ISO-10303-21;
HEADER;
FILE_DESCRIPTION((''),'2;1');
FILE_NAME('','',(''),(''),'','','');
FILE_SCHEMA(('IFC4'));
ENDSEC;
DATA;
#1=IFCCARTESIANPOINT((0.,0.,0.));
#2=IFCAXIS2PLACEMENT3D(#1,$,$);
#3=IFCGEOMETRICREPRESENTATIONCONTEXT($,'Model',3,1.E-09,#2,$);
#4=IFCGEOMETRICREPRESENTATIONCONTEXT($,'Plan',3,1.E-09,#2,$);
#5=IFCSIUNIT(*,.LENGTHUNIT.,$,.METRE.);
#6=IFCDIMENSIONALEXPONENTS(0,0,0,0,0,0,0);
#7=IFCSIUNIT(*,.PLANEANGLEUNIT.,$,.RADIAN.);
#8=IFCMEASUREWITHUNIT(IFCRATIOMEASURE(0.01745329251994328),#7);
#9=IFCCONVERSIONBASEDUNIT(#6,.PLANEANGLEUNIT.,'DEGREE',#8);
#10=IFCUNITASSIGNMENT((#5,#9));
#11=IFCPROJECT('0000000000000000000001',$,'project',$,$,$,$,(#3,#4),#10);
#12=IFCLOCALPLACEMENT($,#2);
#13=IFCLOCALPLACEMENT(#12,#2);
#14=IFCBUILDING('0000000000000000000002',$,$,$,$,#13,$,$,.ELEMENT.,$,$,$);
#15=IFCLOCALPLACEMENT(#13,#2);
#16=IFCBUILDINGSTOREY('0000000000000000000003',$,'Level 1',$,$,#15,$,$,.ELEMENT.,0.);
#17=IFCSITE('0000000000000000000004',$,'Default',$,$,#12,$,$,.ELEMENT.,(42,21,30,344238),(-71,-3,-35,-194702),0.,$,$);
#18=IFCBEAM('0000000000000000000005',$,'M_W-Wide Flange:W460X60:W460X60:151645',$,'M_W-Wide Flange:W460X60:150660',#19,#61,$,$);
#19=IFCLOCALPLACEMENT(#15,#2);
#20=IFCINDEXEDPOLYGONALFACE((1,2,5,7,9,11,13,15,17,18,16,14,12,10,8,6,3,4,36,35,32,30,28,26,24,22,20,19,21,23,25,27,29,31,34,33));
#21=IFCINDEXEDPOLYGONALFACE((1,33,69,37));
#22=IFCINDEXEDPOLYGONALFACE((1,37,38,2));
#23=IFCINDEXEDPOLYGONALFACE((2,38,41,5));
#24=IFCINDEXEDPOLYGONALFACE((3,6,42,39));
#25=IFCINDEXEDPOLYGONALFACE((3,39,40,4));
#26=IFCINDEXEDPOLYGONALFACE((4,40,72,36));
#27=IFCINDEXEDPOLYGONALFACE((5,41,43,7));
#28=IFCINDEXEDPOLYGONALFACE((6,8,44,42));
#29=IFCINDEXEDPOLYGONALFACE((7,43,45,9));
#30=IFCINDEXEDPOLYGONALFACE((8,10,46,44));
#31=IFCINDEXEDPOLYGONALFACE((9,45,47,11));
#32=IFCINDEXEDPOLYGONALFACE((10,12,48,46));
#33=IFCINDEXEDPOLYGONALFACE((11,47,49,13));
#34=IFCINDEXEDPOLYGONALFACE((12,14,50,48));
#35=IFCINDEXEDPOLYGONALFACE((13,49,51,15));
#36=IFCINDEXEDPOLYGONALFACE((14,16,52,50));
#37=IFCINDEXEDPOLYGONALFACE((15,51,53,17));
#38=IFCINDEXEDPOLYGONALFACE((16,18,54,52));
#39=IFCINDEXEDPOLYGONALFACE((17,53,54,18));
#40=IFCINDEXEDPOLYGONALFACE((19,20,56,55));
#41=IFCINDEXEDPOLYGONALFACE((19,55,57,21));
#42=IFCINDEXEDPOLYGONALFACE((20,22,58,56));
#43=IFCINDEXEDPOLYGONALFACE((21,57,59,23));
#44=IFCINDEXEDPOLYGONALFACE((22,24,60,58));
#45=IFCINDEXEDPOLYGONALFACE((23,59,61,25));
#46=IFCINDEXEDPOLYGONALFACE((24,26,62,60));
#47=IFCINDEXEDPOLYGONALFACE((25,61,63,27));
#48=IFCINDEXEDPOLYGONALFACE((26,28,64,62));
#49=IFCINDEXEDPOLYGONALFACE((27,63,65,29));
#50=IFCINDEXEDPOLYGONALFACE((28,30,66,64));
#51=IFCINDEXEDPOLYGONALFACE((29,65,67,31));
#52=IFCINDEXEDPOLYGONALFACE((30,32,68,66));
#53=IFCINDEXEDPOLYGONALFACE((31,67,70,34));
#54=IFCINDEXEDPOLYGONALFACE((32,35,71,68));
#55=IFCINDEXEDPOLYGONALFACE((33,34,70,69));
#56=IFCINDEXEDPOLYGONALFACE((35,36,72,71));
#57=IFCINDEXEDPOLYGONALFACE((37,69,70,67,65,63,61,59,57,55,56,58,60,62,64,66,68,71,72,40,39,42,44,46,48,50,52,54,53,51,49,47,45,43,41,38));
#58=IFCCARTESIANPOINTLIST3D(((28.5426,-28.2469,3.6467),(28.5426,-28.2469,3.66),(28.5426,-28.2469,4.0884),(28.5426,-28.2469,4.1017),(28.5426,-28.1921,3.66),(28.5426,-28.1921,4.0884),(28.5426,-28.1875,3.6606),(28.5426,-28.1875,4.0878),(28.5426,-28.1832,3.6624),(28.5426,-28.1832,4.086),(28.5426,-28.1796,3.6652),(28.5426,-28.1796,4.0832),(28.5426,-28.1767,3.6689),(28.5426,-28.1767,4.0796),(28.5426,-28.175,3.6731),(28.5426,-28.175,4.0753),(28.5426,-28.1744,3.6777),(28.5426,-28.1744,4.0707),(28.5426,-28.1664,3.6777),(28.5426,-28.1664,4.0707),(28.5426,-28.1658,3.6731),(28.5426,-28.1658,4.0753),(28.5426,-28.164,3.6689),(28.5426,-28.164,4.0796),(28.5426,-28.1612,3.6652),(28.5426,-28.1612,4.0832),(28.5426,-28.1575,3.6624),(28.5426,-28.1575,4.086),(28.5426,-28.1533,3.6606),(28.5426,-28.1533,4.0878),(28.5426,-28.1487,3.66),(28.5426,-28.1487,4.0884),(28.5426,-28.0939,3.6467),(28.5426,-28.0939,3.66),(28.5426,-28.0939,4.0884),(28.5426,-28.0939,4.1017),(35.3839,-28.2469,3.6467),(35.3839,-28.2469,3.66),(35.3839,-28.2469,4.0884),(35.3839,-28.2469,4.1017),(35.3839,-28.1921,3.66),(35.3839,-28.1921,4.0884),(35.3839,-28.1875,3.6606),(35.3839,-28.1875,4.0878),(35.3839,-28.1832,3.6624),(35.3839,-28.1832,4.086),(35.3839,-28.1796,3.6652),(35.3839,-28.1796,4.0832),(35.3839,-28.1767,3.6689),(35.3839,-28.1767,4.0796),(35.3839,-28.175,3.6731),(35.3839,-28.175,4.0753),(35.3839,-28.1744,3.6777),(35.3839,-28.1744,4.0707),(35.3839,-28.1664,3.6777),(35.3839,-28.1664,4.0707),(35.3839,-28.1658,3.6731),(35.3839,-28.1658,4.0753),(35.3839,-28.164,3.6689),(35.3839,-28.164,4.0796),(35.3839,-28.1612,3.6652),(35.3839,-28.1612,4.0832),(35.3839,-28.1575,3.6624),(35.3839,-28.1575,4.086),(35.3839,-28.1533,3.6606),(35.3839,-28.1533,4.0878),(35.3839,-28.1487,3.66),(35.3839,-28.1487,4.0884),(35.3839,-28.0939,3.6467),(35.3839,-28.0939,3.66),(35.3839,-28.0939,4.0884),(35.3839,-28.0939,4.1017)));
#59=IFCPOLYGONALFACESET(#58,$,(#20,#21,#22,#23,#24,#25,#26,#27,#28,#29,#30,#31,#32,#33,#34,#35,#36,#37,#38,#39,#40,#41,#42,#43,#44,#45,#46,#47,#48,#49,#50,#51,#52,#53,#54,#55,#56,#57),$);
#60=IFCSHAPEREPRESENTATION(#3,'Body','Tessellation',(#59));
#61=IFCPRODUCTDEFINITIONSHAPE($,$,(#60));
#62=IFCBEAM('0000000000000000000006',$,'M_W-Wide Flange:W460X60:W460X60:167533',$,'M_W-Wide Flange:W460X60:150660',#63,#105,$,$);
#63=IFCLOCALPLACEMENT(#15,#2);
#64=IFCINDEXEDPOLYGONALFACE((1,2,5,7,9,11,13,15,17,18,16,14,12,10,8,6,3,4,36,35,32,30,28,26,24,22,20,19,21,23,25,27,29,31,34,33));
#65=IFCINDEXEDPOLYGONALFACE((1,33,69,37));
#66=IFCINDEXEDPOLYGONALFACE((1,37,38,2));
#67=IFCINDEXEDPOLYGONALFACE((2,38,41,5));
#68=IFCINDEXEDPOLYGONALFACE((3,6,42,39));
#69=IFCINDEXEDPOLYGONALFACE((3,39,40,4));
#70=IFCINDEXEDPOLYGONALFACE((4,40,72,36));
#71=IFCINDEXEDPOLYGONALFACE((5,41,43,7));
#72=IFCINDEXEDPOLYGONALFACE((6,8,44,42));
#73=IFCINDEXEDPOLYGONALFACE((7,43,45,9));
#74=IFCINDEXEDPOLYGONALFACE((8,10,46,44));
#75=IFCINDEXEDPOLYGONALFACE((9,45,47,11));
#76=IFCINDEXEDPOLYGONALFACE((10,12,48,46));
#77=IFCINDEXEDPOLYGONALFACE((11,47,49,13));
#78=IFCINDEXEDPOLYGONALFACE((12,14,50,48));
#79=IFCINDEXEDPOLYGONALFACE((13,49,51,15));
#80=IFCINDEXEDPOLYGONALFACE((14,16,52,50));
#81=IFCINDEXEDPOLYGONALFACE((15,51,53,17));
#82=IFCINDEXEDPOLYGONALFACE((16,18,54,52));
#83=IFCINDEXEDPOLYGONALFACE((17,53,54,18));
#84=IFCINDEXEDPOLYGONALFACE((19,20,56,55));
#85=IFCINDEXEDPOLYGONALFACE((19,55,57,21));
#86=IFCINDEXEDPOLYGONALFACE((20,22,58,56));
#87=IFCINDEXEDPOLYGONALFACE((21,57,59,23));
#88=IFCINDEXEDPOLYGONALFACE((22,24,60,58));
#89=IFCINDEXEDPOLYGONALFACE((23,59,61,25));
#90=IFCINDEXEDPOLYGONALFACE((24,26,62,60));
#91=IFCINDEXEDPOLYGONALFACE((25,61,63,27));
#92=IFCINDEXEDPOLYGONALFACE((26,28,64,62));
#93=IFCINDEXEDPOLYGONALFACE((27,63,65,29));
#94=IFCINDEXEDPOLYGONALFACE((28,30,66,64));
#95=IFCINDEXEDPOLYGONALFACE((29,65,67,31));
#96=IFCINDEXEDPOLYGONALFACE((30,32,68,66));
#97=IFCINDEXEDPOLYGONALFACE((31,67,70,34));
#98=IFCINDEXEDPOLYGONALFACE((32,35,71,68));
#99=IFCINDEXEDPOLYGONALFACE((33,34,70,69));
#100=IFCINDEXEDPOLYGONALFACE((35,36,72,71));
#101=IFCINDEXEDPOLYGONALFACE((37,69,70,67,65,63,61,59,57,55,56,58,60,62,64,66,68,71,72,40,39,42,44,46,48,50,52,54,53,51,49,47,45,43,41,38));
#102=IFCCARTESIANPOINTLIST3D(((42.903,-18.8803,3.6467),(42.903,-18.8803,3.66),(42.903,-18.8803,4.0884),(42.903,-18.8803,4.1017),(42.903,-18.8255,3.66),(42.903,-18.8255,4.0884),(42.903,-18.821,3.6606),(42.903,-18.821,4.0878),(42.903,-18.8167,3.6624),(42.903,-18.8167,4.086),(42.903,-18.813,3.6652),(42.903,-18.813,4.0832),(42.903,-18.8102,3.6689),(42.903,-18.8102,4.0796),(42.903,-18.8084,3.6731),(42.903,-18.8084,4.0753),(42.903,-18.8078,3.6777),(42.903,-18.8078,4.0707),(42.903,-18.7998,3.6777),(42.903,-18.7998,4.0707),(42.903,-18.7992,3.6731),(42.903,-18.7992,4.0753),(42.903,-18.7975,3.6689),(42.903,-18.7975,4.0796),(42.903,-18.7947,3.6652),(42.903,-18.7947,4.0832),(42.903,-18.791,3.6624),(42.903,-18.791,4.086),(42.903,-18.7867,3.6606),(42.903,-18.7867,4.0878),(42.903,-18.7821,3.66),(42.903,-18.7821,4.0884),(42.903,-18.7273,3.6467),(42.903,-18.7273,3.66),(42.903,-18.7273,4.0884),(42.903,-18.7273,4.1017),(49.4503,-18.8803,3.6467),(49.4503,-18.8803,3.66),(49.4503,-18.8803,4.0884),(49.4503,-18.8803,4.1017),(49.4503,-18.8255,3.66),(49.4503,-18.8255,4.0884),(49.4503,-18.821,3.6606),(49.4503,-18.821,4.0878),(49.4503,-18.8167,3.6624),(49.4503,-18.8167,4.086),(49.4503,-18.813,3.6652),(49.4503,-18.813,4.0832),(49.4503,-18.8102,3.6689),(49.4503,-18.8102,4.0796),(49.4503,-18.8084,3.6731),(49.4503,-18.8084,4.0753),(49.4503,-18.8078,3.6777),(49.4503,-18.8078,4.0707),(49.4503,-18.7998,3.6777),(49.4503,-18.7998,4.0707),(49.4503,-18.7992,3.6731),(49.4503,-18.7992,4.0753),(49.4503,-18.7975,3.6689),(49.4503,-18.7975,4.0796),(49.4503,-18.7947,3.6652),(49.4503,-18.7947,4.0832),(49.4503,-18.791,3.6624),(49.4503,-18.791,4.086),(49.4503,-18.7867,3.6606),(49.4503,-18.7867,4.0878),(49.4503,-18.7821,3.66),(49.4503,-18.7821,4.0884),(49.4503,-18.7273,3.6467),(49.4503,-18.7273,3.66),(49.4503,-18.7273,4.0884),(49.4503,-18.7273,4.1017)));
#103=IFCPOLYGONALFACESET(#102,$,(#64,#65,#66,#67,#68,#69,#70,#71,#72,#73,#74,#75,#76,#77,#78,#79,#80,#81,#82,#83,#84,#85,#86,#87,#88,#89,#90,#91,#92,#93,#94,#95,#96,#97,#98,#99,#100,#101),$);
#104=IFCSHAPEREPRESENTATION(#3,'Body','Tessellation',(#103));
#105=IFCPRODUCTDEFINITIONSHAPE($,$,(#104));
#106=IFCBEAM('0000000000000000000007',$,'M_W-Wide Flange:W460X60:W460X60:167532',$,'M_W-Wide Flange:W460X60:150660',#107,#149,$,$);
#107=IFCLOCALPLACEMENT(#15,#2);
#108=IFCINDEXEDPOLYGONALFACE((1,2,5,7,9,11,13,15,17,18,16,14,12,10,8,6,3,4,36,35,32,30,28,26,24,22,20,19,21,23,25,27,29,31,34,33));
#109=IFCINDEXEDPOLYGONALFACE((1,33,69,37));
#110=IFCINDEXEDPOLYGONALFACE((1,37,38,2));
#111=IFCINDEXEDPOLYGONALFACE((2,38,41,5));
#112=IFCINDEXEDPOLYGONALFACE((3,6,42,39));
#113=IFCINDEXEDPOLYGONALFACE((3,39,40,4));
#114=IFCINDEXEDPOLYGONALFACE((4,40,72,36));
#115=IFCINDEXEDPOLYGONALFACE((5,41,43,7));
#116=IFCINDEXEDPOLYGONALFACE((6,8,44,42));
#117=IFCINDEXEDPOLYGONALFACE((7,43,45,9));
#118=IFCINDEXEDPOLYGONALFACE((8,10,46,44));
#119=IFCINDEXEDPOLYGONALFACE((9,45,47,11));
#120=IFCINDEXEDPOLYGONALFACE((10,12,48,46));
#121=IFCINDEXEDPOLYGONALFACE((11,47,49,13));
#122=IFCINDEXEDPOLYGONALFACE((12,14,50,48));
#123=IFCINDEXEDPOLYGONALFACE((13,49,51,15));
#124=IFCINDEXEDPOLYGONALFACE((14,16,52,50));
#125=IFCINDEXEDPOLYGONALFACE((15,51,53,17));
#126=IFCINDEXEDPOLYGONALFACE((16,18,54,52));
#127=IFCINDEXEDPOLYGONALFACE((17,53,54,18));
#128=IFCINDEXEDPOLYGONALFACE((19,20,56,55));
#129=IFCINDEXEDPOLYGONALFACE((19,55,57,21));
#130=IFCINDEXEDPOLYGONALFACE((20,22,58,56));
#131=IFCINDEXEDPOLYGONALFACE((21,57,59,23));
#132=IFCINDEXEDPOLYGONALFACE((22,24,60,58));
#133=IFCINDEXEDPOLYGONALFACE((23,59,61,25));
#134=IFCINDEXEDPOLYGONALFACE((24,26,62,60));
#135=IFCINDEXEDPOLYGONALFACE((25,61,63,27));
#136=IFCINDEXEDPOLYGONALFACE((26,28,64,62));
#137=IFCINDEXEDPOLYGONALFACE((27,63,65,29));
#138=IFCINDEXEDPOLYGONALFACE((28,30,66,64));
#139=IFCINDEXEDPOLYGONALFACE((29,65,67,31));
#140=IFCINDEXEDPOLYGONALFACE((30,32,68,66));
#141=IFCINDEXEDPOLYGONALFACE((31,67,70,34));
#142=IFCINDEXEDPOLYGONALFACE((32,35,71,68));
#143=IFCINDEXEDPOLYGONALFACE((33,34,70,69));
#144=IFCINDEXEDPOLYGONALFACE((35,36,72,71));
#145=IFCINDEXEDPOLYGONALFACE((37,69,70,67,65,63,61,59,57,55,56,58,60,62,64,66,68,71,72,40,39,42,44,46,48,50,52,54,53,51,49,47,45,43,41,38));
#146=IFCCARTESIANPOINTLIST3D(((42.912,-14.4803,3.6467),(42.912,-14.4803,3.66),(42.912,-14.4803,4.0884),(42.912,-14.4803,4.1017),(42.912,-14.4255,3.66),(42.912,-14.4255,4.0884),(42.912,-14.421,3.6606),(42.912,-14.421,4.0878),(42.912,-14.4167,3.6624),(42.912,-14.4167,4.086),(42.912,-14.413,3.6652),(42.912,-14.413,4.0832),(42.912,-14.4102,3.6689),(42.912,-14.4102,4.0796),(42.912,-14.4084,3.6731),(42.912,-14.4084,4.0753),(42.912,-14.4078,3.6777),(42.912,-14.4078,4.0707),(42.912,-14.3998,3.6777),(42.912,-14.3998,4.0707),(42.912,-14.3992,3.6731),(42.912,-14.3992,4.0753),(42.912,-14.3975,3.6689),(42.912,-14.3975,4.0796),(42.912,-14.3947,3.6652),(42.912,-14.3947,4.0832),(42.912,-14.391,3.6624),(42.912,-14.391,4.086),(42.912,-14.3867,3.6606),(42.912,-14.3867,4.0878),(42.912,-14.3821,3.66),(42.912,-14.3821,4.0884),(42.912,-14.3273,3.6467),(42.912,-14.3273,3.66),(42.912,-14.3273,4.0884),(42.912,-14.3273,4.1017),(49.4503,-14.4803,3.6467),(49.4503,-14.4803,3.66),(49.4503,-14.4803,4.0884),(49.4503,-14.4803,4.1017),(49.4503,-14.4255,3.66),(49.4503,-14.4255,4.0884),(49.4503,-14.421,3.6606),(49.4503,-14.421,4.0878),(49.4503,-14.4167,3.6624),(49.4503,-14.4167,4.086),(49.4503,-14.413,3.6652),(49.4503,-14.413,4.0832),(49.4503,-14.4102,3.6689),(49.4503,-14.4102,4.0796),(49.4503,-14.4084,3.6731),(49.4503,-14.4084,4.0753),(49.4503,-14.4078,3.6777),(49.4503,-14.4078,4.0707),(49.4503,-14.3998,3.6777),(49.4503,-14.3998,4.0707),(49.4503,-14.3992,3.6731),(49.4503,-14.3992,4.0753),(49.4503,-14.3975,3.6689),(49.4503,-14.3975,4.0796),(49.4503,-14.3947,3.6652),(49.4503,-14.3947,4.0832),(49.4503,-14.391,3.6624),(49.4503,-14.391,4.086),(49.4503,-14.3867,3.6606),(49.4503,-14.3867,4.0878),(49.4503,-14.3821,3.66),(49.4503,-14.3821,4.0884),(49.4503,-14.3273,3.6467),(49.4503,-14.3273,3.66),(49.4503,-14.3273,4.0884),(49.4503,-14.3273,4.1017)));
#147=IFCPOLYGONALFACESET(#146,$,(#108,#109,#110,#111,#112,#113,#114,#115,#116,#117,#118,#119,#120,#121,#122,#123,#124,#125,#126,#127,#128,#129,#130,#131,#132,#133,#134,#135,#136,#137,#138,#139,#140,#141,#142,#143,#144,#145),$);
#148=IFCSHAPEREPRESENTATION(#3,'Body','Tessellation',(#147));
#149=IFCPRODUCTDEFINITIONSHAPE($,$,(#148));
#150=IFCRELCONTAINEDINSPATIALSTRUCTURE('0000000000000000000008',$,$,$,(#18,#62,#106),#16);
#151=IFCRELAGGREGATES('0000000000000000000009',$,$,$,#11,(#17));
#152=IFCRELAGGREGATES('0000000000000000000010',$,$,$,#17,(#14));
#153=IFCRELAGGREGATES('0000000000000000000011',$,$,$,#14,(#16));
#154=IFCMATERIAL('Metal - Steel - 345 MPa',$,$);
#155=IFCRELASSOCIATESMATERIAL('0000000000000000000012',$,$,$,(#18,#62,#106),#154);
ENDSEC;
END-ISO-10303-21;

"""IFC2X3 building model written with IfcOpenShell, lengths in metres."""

from ifc_helpers import new_model, entity, si_unit, converted_unit, frame, frame_2d, origin, place, context, project, spatial, polyline, circle_curve, parameter, trimmed, segment, composite_curve, outline, extrude, material, element, save


model = new_model("IFC2X3")

# Units and contexts
model_context = context("Model", 3, precision=1e-09, world=origin())
plan_context = context("Plan", 3, precision=1e-09, world=origin())
ifc_project = project(units=[si_unit("LENGTHUNIT", "METRE"), converted_unit("PLANEANGLEUNIT", "DEGREE", entity("IfcRatioMeasure", 0.01745329251994328), si_unit("PLANEANGLEUNIT", "RADIAN"), dimensions=[0, 0, 0, 0, 0, 0, 0])], contexts=[model_context, plan_context])

# Site, building, storey
site_placement = place(None, origin())
site = spatial("IfcSite", under=ifc_project, at=site_placement, Name="Default", CompositionType="ELEMENT", RefLatitude=(42, 21, 30, 344238), RefLongitude=(-71, -3, -35, -194702), RefElevation=0.0)
building_placement = place(site_placement, origin())
building = spatial("IfcBuilding", under=site, at=building_placement, CompositionType="ELEMENT")
storey_placement = place(building_placement, origin())
storey = spatial("IfcBuildingStorey", under=building, at=storey_placement, Name="Level 1", CompositionType="ELEMENT", Elevation=0.0)

# Beams
ifc_material = material(Name="Metal - Steel - 345 MPa")
beam_1_placement = place(storey_placement, frame((28.4279, -28.1704, 4.2672), z_axis=(0.0, 0.0, 1.0), x_axis=(0.0, -1.0, 0.0)))
element("IfcBeam", 1, at=beam_1_placement, inside=storey, material=ifc_material, Name="M_W-Wide Flange:W460X60:W460X60:151645", ObjectType="M_W-Wide Flange:W460X60:150660", context=model_context, shape_type="SweptSolid", body=[
    extrude(outline(composite_curve([segment(polyline([(-0.0765, -0.2142), (-0.0765, -0.2275)]), True, "CONTINUOUS"), segment(polyline([(-0.0765, -0.2275), (0.0765, -0.2275)]), True, "CONTINUOUS"), segment(polyline([(0.0765, -0.2275), (0.0765, -0.2142)]), True, "CONTINUOUS"), segment(polyline([(0.0765, -0.2142), (0.0217, -0.2142)]), True, "CONTINUOUS"), segment(trimmed(circle_curve(frame_2d((0.0217, -0.1965), x_axis=(0.0, -1.0)), 0.0177), [parameter(270.0)], [parameter(360.0)], True, "PARAMETER"), False, "CONTINUOUS"), segment(polyline([(0.004, -0.1965), (0.004, 0.1965)]), True, "CONTINUOUS"), segment(trimmed(circle_curve(frame_2d((0.0217, 0.1965), x_axis=(-1.0, 0.0)), 0.0177), [parameter(270.0)], [parameter(360.0)], True, "PARAMETER"), False, "CONTINUOUS"), segment(polyline([(0.0217, 0.2142), (0.0765, 0.2142)]), True, "CONTINUOUS"), segment(polyline([(0.0765, 0.2142), (0.0765, 0.2275)]), True, "CONTINUOUS"), segment(polyline([(0.0765, 0.2275), (-0.0765, 0.2275)]), True, "CONTINUOUS"), segment(polyline([(-0.0765, 0.2275), (-0.0765, 0.2142)]), True, "CONTINUOUS"), segment(polyline([(-0.0765, 0.2142), (-0.0217, 0.2142)]), True, "CONTINUOUS"), segment(trimmed(circle_curve(frame_2d((-0.0217, 0.1965), x_axis=(0.0, 1.0)), 0.0177), [parameter(270.0)], [parameter(360.0)], True, "PARAMETER"), False, "CONTINUOUS"), segment(polyline([(-0.004, 0.1965), (-0.004, -0.1965)]), True, "CONTINUOUS"), segment(trimmed(circle_curve(frame_2d((-0.0217, -0.1965), x_axis=(1.0, 0.0)), 0.0177), [parameter(270.0)], [parameter(0.0)], True, "PARAMETER"), False, "CONTINUOUS"), segment(polyline([(-0.0217, -0.2142), (-0.0765, -0.2142)]), True, "CONTINUOUS")], self_intersect=False)), frame((0.0, 0.1147, -0.393), z_axis=(0.0, -1.0, 0.0), x_axis=(1.0, 0.0, 0.0)), (0.0, 0.0, -1.0), 6.8414),
])
beam_2_placement = place(storey_placement, frame((43.6829, -18.8038, 4.2672), z_axis=(0.0, 0.0, 1.0), x_axis=(0.0, -1.0, 0.0)))
element("IfcBeam", 2, at=beam_2_placement, inside=storey, material=ifc_material, Name="M_W-Wide Flange:W460X60:W460X60:167533", ObjectType="M_W-Wide Flange:W460X60:150660", context=model_context, shape_type="SweptSolid", body=[
    extrude(outline(composite_curve([segment(polyline([(0.2142, -0.0765), (0.2275, -0.0765)]), True, "CONTINUOUS"), segment(polyline([(0.2275, -0.0765), (0.2275, 0.0765)]), True, "CONTINUOUS"), segment(polyline([(0.2275, 0.0765), (0.2142, 0.0765)]), True, "CONTINUOUS"), segment(polyline([(0.2142, 0.0765), (0.2142, 0.0217)]), True, "CONTINUOUS"), segment(trimmed(circle_curve(frame_2d((0.1965, 0.0217), x_axis=(0.0, 1.0)), 0.0177), [parameter(180.0)], [parameter(270.0)], True, "PARAMETER"), False, "CONTINUOUS"), segment(polyline([(0.1965, 0.004), (-0.1965, 0.004)]), True, "CONTINUOUS"), segment(trimmed(circle_curve(frame_2d((-0.1965, 0.0217), x_axis=(0.0, 1.0)), 0.0177), [parameter(90.0)], [parameter(180.0)], True, "PARAMETER"), False, "CONTINUOUS"), segment(polyline([(-0.2142, 0.0217), (-0.2142, 0.0765)]), True, "CONTINUOUS"), segment(polyline([(-0.2142, 0.0765), (-0.2275, 0.0765)]), True, "CONTINUOUS"), segment(polyline([(-0.2275, 0.0765), (-0.2275, -0.0765)]), True, "CONTINUOUS"), segment(polyline([(-0.2275, -0.0765), (-0.2142, -0.0765)]), True, "CONTINUOUS"), segment(polyline([(-0.2142, -0.0765), (-0.2142, -0.0217)]), True, "CONTINUOUS"), segment(trimmed(circle_curve(frame_2d((-0.1965, -0.0217), x_axis=(0.0, 1.0)), 0.0177), [parameter(360.0)], [parameter(90.0)], True, "PARAMETER"), False, "CONTINUOUS"), segment(polyline([(-0.1965, -0.004), (0.1965, -0.004)]), True, "CONTINUOUS"), segment(trimmed(circle_curve(frame_2d((0.1965, -0.0217), x_axis=(0.0, 1.0)), 0.0177), [parameter(270.0)], [parameter(0.0)], True, "PARAMETER"), False, "CONTINUOUS"), segment(polyline([(0.2142, -0.0217), (0.2142, -0.0765)]), True, "CONTINUOUS")], self_intersect=False)), frame((0.0, -0.7799, -0.393), z_axis=(0.0, 1.0, 0.0), x_axis=(0.0, 0.0, -1.0)), (0.0, 0.0, 1.0), 6.5473),
])
beam_3_placement = place(storey_placement, frame((43.6829, -14.4038, 4.2672), z_axis=(0.0, 0.0, 1.0), x_axis=(0.0, -1.0, 0.0)))
element("IfcBeam", 3, at=beam_3_placement, inside=storey, material=ifc_material, Name="M_W-Wide Flange:W460X60:W460X60:167532", ObjectType="M_W-Wide Flange:W460X60:150660", context=model_context, shape_type="SweptSolid", body=[
    extrude(outline(composite_curve([segment(polyline([(0.2142, -0.0765), (0.2275, -0.0765)]), True, "CONTINUOUS"), segment(polyline([(0.2275, -0.0765), (0.2275, 0.0765)]), True, "CONTINUOUS"), segment(polyline([(0.2275, 0.0765), (0.2142, 0.0765)]), True, "CONTINUOUS"), segment(polyline([(0.2142, 0.0765), (0.2142, 0.0217)]), True, "CONTINUOUS"), segment(trimmed(circle_curve(frame_2d((0.1965, 0.0217), x_axis=(0.0, 1.0)), 0.0177), [parameter(180.0)], [parameter(270.0)], True, "PARAMETER"), False, "CONTINUOUS"), segment(polyline([(0.1965, 0.004), (-0.1965, 0.004)]), True, "CONTINUOUS"), segment(trimmed(circle_curve(frame_2d((-0.1965, 0.0217), x_axis=(0.0, 1.0)), 0.0177), [parameter(90.0)], [parameter(180.0)], True, "PARAMETER"), False, "CONTINUOUS"), segment(polyline([(-0.2142, 0.0217), (-0.2142, 0.0765)]), True, "CONTINUOUS"), segment(polyline([(-0.2142, 0.0765), (-0.2275, 0.0765)]), True, "CONTINUOUS"), segment(polyline([(-0.2275, 0.0765), (-0.2275, -0.0765)]), True, "CONTINUOUS"), segment(polyline([(-0.2275, -0.0765), (-0.2142, -0.0765)]), True, "CONTINUOUS"), segment(polyline([(-0.2142, -0.0765), (-0.2142, -0.0217)]), True, "CONTINUOUS"), segment(trimmed(circle_curve(frame_2d((-0.1965, -0.0217), x_axis=(0.0, 1.0)), 0.0177), [parameter(360.0)], [parameter(90.0)], True, "PARAMETER"), False, "CONTINUOUS"), segment(polyline([(-0.1965, -0.004), (0.1965, -0.004)]), True, "CONTINUOUS"), segment(trimmed(circle_curve(frame_2d((0.1965, -0.0217), x_axis=(0.0, 1.0)), 0.0177), [parameter(270.0)], [parameter(0.0)], True, "PARAMETER"), False, "CONTINUOUS"), segment(polyline([(0.2142, -0.0217), (0.2142, -0.0765)]), True, "CONTINUOUS")], self_intersect=False)), frame((0.0, -0.7709, -0.393), z_axis=(0.0, 1.0, 0.0), x_axis=(0.0, 0.0, -1.0)), (0.0, 0.0, 1.0), 6.5383),
])

save(model, "model.ifc")
